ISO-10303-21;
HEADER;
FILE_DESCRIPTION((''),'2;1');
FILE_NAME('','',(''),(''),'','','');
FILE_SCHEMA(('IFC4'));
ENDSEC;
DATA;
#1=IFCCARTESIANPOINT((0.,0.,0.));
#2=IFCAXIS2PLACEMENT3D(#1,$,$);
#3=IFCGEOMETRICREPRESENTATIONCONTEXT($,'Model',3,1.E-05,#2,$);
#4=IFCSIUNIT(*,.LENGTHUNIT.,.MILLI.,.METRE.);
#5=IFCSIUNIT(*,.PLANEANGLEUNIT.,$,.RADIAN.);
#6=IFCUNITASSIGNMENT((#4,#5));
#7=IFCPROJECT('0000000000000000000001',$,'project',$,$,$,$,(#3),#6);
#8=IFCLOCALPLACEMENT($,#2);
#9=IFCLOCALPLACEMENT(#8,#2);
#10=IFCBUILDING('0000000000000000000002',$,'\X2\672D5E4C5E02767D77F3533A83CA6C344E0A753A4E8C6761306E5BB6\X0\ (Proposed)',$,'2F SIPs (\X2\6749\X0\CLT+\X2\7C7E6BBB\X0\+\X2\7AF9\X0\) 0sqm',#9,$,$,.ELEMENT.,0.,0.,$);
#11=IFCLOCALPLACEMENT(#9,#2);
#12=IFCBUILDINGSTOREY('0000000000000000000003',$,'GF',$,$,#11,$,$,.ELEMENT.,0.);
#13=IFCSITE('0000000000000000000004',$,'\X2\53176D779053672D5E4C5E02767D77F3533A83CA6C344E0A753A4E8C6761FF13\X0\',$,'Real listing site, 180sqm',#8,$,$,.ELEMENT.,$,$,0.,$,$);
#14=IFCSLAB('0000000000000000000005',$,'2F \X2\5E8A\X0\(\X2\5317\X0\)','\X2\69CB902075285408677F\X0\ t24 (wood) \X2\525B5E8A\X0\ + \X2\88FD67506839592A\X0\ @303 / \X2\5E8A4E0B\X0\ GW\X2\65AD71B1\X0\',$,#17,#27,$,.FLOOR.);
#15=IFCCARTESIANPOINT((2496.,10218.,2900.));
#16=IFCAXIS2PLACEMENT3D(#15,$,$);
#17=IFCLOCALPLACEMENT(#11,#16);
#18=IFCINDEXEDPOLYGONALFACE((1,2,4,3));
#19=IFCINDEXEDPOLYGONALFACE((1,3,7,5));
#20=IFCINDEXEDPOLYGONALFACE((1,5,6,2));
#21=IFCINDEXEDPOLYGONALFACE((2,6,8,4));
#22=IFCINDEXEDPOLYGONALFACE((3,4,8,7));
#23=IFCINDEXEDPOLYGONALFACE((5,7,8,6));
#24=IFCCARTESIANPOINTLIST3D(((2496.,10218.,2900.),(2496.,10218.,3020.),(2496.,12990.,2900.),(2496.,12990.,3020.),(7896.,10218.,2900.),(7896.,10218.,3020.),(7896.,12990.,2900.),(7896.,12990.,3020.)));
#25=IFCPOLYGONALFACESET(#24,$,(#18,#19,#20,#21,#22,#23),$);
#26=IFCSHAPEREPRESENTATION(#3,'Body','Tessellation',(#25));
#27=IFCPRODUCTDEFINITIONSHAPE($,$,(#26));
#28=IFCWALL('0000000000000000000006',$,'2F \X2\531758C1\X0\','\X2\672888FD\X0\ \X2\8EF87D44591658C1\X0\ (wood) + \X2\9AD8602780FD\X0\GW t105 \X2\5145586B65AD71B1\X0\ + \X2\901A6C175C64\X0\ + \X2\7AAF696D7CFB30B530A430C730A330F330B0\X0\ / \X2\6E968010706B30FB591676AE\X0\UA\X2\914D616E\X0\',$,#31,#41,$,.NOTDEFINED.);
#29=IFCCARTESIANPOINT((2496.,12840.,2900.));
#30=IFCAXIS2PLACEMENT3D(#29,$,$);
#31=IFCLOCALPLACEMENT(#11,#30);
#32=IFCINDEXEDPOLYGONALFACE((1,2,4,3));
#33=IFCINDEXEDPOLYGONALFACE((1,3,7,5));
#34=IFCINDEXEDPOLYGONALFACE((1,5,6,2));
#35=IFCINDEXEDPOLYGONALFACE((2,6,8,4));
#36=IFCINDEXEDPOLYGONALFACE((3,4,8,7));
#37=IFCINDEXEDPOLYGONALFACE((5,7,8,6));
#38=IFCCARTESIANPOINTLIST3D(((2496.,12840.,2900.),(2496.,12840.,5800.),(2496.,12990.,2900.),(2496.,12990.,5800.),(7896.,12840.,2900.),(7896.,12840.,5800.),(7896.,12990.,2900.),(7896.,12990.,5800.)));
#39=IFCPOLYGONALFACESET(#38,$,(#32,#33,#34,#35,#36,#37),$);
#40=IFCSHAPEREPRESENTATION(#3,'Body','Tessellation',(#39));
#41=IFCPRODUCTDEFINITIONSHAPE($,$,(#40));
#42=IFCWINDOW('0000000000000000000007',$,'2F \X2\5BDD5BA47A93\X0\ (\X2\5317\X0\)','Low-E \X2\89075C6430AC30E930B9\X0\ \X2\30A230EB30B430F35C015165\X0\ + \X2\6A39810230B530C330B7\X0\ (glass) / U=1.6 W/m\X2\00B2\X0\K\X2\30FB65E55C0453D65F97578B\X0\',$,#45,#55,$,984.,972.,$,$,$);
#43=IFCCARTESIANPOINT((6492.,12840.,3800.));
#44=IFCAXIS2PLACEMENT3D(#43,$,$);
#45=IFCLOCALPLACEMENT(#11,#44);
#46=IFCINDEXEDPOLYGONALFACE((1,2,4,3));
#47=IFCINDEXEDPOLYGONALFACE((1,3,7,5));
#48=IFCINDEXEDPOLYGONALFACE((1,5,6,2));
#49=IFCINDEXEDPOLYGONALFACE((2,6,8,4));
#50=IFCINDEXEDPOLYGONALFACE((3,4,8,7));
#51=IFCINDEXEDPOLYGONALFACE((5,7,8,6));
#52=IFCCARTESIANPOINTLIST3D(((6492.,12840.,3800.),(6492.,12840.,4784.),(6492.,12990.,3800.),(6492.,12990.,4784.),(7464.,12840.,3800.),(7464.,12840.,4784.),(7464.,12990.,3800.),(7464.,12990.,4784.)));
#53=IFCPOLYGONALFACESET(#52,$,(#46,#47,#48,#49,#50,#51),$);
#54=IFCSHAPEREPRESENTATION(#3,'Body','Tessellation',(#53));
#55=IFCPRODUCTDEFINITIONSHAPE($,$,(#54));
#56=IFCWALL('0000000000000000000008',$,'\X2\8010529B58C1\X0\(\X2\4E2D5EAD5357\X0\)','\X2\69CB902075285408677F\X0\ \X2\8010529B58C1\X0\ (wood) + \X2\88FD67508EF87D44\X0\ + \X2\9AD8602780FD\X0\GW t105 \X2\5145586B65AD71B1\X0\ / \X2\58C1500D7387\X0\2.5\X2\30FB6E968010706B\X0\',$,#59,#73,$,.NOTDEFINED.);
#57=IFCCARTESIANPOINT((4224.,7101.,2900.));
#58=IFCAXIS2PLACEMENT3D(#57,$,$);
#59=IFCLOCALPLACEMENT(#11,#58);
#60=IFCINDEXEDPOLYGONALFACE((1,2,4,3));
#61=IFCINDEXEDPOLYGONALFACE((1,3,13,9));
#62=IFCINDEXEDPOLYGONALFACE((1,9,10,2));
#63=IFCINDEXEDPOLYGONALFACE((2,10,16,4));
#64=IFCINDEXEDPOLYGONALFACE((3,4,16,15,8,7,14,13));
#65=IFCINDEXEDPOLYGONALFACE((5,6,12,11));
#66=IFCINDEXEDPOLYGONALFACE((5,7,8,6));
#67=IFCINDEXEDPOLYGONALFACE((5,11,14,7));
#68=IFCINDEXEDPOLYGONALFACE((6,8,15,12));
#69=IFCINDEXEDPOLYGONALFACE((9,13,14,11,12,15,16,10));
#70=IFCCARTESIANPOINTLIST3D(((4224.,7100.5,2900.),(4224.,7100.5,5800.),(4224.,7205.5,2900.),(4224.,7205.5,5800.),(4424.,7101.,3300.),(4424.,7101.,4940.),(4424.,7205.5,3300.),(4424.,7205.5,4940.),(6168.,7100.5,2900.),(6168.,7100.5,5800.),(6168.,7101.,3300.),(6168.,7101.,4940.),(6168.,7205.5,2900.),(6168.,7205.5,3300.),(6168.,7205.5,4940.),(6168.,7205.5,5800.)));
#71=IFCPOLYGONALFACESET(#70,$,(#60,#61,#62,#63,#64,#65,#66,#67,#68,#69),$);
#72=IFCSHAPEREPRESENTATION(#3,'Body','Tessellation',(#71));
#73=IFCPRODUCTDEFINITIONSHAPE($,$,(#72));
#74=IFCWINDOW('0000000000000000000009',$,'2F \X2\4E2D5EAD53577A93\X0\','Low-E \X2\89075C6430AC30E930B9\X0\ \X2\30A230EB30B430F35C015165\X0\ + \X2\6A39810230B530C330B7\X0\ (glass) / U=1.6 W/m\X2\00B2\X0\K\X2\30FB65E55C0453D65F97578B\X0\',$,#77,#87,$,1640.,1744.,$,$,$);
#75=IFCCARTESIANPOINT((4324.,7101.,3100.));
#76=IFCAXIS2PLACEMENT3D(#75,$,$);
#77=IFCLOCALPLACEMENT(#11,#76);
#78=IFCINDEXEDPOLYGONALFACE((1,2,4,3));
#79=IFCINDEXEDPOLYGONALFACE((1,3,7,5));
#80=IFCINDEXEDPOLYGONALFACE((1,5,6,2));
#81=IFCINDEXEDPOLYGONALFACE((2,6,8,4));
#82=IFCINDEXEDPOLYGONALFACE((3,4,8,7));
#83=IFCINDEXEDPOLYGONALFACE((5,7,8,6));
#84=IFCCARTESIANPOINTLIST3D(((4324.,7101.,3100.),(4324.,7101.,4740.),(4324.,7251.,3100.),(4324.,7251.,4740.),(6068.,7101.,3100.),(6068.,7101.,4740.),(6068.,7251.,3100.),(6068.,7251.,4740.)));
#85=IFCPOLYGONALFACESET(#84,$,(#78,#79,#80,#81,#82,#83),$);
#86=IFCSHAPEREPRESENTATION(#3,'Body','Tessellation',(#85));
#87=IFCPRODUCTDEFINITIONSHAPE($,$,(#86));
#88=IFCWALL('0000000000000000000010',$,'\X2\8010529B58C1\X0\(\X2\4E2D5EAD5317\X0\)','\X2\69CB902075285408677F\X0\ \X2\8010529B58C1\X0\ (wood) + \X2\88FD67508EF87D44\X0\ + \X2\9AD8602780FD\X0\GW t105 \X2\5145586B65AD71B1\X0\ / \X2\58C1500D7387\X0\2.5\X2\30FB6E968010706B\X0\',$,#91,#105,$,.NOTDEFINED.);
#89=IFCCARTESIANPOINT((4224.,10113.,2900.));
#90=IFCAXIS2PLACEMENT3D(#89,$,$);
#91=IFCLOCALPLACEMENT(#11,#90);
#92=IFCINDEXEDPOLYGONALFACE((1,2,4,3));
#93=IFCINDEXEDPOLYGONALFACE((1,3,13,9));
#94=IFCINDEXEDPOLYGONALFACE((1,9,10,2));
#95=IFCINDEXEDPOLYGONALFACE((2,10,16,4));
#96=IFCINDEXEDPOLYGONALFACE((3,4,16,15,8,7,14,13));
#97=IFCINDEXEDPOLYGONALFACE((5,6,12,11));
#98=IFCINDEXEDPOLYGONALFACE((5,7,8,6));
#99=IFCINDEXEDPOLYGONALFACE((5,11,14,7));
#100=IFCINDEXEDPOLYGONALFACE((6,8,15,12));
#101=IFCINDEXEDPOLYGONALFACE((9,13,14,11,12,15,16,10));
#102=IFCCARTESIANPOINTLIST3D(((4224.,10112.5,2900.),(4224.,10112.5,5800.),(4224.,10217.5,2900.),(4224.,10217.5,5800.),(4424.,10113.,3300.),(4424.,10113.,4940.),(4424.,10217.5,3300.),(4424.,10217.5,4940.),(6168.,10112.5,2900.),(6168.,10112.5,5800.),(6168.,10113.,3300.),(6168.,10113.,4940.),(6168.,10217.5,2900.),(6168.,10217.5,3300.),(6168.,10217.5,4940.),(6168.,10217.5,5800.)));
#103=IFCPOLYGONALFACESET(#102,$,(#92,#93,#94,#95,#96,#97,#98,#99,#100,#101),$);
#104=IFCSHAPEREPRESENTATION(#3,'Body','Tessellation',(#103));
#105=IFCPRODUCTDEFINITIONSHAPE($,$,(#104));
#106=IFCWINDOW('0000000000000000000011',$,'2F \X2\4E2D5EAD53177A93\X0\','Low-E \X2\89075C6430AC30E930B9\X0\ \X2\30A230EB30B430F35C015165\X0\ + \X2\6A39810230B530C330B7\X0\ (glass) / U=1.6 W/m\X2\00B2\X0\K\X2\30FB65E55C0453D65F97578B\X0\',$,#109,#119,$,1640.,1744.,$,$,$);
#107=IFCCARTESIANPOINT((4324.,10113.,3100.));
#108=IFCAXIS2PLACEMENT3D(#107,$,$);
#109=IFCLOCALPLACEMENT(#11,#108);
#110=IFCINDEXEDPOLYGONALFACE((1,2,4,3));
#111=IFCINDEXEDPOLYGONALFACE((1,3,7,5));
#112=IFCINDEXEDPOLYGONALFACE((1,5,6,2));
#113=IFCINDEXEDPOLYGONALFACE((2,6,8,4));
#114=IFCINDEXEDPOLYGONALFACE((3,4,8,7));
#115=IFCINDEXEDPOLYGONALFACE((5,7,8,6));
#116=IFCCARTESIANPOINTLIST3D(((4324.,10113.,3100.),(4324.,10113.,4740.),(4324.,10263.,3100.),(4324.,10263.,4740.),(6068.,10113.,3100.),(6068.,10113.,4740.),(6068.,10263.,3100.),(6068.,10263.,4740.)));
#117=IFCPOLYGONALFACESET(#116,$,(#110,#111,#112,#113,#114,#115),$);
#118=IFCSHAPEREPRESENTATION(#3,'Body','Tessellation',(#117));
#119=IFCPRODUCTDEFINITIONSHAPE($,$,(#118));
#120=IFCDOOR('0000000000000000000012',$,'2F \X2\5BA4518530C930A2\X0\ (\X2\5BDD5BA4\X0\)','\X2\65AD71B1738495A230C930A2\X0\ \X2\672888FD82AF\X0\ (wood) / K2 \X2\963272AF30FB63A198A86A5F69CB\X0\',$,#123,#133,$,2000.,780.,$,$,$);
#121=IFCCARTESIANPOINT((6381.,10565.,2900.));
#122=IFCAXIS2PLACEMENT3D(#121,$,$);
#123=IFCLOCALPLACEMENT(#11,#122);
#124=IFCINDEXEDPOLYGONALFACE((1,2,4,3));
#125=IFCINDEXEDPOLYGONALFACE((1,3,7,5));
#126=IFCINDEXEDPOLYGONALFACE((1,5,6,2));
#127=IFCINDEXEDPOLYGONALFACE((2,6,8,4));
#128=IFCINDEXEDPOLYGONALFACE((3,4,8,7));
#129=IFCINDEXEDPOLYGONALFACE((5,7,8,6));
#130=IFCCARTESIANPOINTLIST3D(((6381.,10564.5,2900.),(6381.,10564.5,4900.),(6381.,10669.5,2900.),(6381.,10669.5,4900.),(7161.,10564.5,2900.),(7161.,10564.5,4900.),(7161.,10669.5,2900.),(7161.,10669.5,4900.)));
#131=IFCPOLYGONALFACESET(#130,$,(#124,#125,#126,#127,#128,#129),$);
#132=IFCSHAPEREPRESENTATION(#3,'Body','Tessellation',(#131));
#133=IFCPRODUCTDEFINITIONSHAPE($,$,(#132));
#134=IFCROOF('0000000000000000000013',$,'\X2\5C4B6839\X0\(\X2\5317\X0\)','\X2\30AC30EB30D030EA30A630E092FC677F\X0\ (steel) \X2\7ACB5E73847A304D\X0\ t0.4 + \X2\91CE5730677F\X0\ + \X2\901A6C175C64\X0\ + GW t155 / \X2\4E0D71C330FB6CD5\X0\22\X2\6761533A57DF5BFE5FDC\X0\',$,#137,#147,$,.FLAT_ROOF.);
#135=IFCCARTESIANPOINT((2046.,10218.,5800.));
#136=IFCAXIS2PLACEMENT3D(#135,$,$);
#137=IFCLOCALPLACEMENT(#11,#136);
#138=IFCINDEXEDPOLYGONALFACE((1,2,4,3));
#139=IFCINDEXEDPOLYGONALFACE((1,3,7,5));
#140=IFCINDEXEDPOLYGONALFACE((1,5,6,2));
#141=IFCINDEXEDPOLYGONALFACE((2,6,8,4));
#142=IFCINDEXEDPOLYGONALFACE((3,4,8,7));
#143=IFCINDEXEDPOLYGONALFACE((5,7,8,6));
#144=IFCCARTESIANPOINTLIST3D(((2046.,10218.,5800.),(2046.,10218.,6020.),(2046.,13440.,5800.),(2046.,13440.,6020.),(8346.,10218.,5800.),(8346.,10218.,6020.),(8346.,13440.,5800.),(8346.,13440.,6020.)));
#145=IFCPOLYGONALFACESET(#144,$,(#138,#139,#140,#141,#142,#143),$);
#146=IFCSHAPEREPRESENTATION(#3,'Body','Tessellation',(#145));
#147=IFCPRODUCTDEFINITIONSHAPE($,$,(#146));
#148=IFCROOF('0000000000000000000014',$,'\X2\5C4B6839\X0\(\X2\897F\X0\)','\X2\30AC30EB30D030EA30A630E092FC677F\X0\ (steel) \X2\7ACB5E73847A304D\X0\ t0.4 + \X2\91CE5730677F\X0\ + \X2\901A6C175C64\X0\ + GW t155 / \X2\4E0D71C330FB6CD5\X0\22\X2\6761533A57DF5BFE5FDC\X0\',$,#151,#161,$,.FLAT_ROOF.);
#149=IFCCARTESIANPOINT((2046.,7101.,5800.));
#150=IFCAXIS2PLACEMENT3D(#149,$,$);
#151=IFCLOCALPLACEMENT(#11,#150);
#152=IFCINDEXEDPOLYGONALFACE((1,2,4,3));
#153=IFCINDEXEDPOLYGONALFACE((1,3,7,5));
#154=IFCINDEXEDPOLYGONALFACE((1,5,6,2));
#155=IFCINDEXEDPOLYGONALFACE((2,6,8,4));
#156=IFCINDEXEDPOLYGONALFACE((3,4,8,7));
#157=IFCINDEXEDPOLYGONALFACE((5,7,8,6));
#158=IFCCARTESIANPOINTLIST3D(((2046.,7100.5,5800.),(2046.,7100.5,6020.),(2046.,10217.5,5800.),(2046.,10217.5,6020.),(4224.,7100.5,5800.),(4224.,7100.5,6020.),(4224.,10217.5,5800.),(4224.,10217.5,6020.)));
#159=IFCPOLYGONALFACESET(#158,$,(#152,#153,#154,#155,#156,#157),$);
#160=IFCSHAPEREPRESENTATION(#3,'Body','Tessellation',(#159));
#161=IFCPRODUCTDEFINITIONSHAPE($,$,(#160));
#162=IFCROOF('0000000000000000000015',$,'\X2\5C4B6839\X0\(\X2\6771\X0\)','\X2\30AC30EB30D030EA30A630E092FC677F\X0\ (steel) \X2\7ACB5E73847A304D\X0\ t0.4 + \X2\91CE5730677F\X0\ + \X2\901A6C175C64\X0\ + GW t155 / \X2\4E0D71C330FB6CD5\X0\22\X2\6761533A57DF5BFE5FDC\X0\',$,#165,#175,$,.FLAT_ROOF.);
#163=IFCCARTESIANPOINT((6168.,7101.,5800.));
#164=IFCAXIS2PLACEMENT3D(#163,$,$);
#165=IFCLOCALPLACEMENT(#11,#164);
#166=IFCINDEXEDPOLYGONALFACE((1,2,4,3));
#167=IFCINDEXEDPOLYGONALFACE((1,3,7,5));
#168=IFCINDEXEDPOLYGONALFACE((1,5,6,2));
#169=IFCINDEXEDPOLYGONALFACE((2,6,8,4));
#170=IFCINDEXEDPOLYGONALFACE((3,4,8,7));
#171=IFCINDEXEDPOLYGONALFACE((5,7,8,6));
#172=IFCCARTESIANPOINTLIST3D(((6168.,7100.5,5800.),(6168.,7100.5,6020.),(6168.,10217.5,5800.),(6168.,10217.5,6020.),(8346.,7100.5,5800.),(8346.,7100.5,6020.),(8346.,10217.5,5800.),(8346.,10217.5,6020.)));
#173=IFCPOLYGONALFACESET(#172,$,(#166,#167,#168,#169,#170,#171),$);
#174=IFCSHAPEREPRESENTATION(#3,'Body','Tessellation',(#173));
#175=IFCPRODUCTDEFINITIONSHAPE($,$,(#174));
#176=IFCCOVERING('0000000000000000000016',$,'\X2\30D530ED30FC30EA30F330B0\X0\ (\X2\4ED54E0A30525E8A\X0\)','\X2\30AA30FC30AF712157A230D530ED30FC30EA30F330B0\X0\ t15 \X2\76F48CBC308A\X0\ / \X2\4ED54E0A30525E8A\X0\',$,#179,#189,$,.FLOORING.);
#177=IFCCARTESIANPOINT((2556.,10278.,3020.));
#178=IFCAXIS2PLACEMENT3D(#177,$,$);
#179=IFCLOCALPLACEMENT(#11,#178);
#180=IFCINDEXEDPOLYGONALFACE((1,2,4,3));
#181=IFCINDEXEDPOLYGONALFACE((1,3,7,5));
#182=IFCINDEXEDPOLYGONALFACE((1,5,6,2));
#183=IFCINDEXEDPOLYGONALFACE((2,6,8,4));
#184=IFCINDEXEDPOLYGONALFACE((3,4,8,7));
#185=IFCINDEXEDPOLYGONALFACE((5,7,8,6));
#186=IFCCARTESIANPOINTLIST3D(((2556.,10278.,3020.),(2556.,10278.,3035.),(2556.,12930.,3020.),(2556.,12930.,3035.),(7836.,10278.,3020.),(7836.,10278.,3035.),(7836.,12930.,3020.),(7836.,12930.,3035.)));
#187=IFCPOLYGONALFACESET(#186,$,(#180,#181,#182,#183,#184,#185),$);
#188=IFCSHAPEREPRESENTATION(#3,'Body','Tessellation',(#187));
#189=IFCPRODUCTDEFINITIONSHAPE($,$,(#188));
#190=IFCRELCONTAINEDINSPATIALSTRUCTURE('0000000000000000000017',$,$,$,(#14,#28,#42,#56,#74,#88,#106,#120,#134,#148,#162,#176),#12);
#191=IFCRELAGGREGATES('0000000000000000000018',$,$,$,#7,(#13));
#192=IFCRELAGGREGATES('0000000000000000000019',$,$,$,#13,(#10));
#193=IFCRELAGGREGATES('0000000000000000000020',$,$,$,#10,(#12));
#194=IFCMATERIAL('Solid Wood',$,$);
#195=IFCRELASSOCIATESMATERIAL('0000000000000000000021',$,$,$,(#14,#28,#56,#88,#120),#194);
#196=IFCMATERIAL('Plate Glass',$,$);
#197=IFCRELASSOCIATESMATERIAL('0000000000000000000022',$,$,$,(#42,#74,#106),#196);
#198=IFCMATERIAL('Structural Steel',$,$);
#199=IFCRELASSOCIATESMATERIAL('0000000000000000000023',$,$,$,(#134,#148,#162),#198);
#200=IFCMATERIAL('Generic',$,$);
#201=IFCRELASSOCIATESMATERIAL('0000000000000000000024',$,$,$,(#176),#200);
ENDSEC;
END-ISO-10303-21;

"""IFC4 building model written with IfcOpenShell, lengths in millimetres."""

from ifc_helpers import new_model, si_unit, frame, frame_2d, origin, place, context, project, spatial, rectangle, extrude, material, element, fill, save


model = new_model("IFC4")

# Units and contexts
model_context = context("Model", 3, precision=1e-05, world=origin())
ifc_project = project(units=[si_unit("LENGTHUNIT", "METRE", prefix="MILLI"), si_unit("PLANEANGLEUNIT", "RADIAN")], contexts=[model_context])

# Site, building, storey
site_placement = place(None, origin())
site = spatial("IfcSite", under=ifc_project, at=site_placement, Name="北海道札幌市白石区菊水上町二条３", ObjectType="Real listing site, 180sqm", CompositionType="ELEMENT", RefElevation=0.0)
building_placement = place(site_placement, origin())
building = spatial("IfcBuilding", under=site, at=building_placement, Name="札幌市白石区菊水上町二条の家 (Proposed)", ObjectType="2F SIPs (杉CLT+籾殻+竹) 0sqm", CompositionType="ELEMENT", ElevationOfRefHeight=0.0, ElevationOfTerrain=0.0)
storey_placement = place(building_placement, origin())
storey = spatial("IfcBuildingStorey", under=building, at=storey_placement, Name="GF", CompositionType="ELEMENT", Elevation=0.0)

# Slab
ifc_material_1 = material(Name="Solid Wood")
slab_placement = place(storey_placement, frame((2496.0, 10218.0, 2900.0)))
element("IfcSlab", 1, at=slab_placement, inside=storey, material=ifc_material_1, Name="2F 床(北)", Description="構造用合板 t24 (wood) 剛床 + 製材根太 @303 / 床下 GW断熱", PredefinedType="FLOOR", context=model_context, shape_type="SweptSolid", body=[
    extrude(rectangle(XDim=5400.0, YDim=2772.0, at=frame_2d((2700.0, 1386.0))), frame((2496.0, 10218.0, 2900.0)), (0.0, 0.0, 1.0), 120.0),
])

# Walls, openings, windows
wall_1_placement = place(storey_placement, frame((2496.0, 12840.0, 2900.0)))
wall_1 = element("IfcWall", 2, at=wall_1_placement, inside=storey, material=ifc_material_1, Name="2F 北壁", Description="木製 軸組外壁 (wood) + 高性能GW t105 充填断熱 + 通気層 + 窯業系サイディング / 準耐火・外皮UA配慮", PredefinedType="NOTDEFINED", context=model_context, shape_type="SweptSolid", body=[
    extrude(rectangle(XDim=5400.0, YDim=150.0, at=frame_2d((2700.0, 75.0))), frame((2496.0, 12840.0, 2900.0)), (0.0, 0.0, 1.0), 2900.0),
])
opening_1_placement = place(storey_placement, frame((6492.0, 12840.0, 3800.0)))
opening_1 = element("IfcOpeningElement", 3, at=opening_1_placement, cuts=wall_1, PredefinedType="NOTDEFINED", context=model_context, shape_type="SweptSolid", body=[
    extrude(rectangle(XDim=972.0, YDim=150.0, at=frame_2d((486.0, 75.0))), frame((6492.0, 12840.0, 3800.0)), (0.0, 0.0, 1.0), 984.0),
])
ifc_material_2 = material(Name="Plate Glass")
window_1_placement = place(storey_placement, frame((6492.0, 12840.0, 3800.0)))
window_1 = element("IfcWindow", 4, at=window_1_placement, inside=storey, material=ifc_material_2, Name="2F 寝室窓 (北)", Description="Low-E 複層ガラス アルゴン封入 + 樹脂サッシ (glass) / U=1.6 W/m²K・日射取得型", OverallHeight=984.0, OverallWidth=972.0, context=model_context, shape_type="SweptSolid", body=[
    extrude(rectangle(XDim=972.0, YDim=150.0, at=frame_2d((486.0, 75.0))), frame((6492.0, 12840.0, 3800.0)), (0.0, 0.0, 1.0), 984.0),
])
fill(opening_1, window_1)
wall_2_placement = place(storey_placement, frame((4224.0, 7101.0, 2900.0)))
wall_2 = element("IfcWall", 5, at=wall_2_placement, inside=storey, material=ifc_material_1, Name="耐力壁(中庭南)", Description="構造用合板 耐力壁 (wood) + 製材軸組 + 高性能GW t105 充填断熱 / 壁倍率2.5・準耐火", PredefinedType="NOTDEFINED", context=model_context, shape_type="SweptSolid", body=[
    extrude(rectangle(XDim=1944.0, YDim=105.0, at=frame_2d((972.0, 52.0))), frame((4224.0, 7101.0, 2900.0)), (0.0, 0.0, 1.0), 2900.0),
])
opening_2_placement = place(storey_placement, frame((4324.0, 7101.0, 3100.0)))
opening_2 = element("IfcOpeningElement", 6, at=opening_2_placement, cuts=wall_2, PredefinedType="NOTDEFINED", context=model_context, shape_type="SweptSolid", body=[
    extrude(rectangle(XDim=1744.0, YDim=150.0, at=frame_2d((872.0, 75.0))), frame((4324.0, 7101.0, 3100.0)), (0.0, 0.0, 1.0), 1640.0),
])
window_2_placement = place(storey_placement, frame((4324.0, 7101.0, 3100.0)))
window_2 = element("IfcWindow", 7, at=window_2_placement, inside=storey, material=ifc_material_2, Name="2F 中庭南窓", Description="Low-E 複層ガラス アルゴン封入 + 樹脂サッシ (glass) / U=1.6 W/m²K・日射取得型", OverallHeight=1640.0, OverallWidth=1744.0, context=model_context, shape_type="SweptSolid", body=[
    extrude(rectangle(XDim=1744.0, YDim=150.0, at=frame_2d((872.0, 75.0))), frame((4324.0, 7101.0, 3100.0)), (0.0, 0.0, 1.0), 1640.0),
])
fill(opening_2, window_2)
wall_3_placement = place(storey_placement, frame((4224.0, 10113.0, 2900.0)))
wall_3 = element("IfcWall", 8, at=wall_3_placement, inside=storey, material=ifc_material_1, Name="耐力壁(中庭北)", Description="構造用合板 耐力壁 (wood) + 製材軸組 + 高性能GW t105 充填断熱 / 壁倍率2.5・準耐火", PredefinedType="NOTDEFINED", context=model_context, shape_type="SweptSolid", body=[
    extrude(rectangle(XDim=1944.0, YDim=105.0, at=frame_2d((972.0, 52.0))), frame((4224.0, 10113.0, 2900.0)), (0.0, 0.0, 1.0), 2900.0),
])
opening_3_placement = place(storey_placement, frame((4324.0, 10113.0, 3100.0)))
opening_3 = element("IfcOpeningElement", 9, at=opening_3_placement, cuts=wall_3, PredefinedType="NOTDEFINED", context=model_context, shape_type="SweptSolid", body=[
    extrude(rectangle(XDim=1744.0, YDim=150.0, at=frame_2d((872.0, 75.0))), frame((4324.0, 10113.0, 3100.0)), (0.0, 0.0, 1.0), 1640.0),
])
window_3_placement = place(storey_placement, frame((4324.0, 10113.0, 3100.0)))
window_3 = element("IfcWindow", 10, at=window_3_placement, inside=storey, material=ifc_material_2, Name="2F 中庭北窓", Description="Low-E 複層ガラス アルゴン封入 + 樹脂サッシ (glass) / U=1.6 W/m²K・日射取得型", OverallHeight=1640.0, OverallWidth=1744.0, context=model_context, shape_type="SweptSolid", body=[
    extrude(rectangle(XDim=1744.0, YDim=150.0, at=frame_2d((872.0, 75.0))), frame((4324.0, 10113.0, 3100.0)), (0.0, 0.0, 1.0), 1640.0),
])
fill(opening_3, window_3)

# Door
door_placement = place(storey_placement, frame((6381.0, 10565.0, 2900.0)))
element("IfcDoor", 11, at=door_placement, inside=storey, material=ifc_material_1, Name="2F 室内ドア (寝室)", Description="断熱玄関ドア 木製芯 (wood) / K2 防犯・採風機構", OverallHeight=2000.0, OverallWidth=780.0, context=model_context, shape_type="SweptSolid", body=[
    extrude(rectangle(XDim=780.0, YDim=105.0, at=frame_2d((390.0, 52.0))), frame((6381.0, 10565.0, 2900.0)), (0.0, 0.0, 1.0), 2000.0),
])

# Roofs
ifc_material_3 = material(Name="Structural Steel")
for number, where, name in (
    (12, (2046.0, 10218.0, 5800.0), "屋根(北)"),
):
    element("IfcRoof", number, at=place(storey_placement, frame(where)), inside=storey, material=ifc_material_3, Name=name, Description="ガルバリウム鋼板 (steel) 立平葺き t0.4 + 野地板 + 通気層 + GW t155 / 不燃・法22条区域対応", PredefinedType="FLAT_ROOF", context=model_context, shape_type="SweptSolid", body=[
        extrude(rectangle(XDim=6300.0, YDim=3222.0, at=frame_2d((3150.0, 1611.0))), frame((2046.0, 10218.0, 5800.0)), (0.0, 0.0, 1.0), 220.0),
    ])
roof_1_placement = place(storey_placement, frame((2046.0, 7101.0, 5800.0)))
element("IfcRoof", 13, at=roof_1_placement, inside=storey, material=ifc_material_3, Name="屋根(西)", Description="ガルバリウム鋼板 (steel) 立平葺き t0.4 + 野地板 + 通気層 + GW t155 / 不燃・法22条区域対応", PredefinedType="FLAT_ROOF", context=model_context, shape_type="SweptSolid", body=[
    extrude(rectangle(XDim=2178.0, YDim=3117.0, at=frame_2d((1089.0, 1558.0))), frame((2046.0, 7101.0, 5800.0)), (0.0, 0.0, 1.0), 220.0),
])
roof_2_placement = place(storey_placement, frame((6168.0, 7101.0, 5800.0)))
element("IfcRoof", 14, at=roof_2_placement, inside=storey, material=ifc_material_3, Name="屋根(東)", Description="ガルバリウム鋼板 (steel) 立平葺き t0.4 + 野地板 + 通気層 + GW t155 / 不燃・法22条区域対応", PredefinedType="FLAT_ROOF", context=model_context, shape_type="SweptSolid", body=[
    extrude(rectangle(XDim=2178.0, YDim=3117.0, at=frame_2d((1089.0, 1558.0))), frame((6168.0, 7101.0, 5800.0)), (0.0, 0.0, 1.0), 220.0),
])

# Covering
ifc_material_4 = material(Name="Generic")
covering_1_placement = place(storey_placement, frame((2556.0, 10278.0, 3020.0)))
element("IfcCovering", 15, at=covering_1_placement, inside=storey, material=ifc_material_4, Name="フローリング (仕上げ床)", Description="オーク無垢フローリング t15 直貼り / 仕上げ床", PredefinedType="FLOORING", context=model_context, shape_type="SweptSolid", body=[
    extrude(rectangle(XDim=5280.0, YDim=2652.0, at=frame_2d((2640.0, 1326.0))), frame((2556.0, 10278.0, 3020.0)), (0.0, 0.0, 1.0), 15.0),
])

save(model, "model.ifc")
